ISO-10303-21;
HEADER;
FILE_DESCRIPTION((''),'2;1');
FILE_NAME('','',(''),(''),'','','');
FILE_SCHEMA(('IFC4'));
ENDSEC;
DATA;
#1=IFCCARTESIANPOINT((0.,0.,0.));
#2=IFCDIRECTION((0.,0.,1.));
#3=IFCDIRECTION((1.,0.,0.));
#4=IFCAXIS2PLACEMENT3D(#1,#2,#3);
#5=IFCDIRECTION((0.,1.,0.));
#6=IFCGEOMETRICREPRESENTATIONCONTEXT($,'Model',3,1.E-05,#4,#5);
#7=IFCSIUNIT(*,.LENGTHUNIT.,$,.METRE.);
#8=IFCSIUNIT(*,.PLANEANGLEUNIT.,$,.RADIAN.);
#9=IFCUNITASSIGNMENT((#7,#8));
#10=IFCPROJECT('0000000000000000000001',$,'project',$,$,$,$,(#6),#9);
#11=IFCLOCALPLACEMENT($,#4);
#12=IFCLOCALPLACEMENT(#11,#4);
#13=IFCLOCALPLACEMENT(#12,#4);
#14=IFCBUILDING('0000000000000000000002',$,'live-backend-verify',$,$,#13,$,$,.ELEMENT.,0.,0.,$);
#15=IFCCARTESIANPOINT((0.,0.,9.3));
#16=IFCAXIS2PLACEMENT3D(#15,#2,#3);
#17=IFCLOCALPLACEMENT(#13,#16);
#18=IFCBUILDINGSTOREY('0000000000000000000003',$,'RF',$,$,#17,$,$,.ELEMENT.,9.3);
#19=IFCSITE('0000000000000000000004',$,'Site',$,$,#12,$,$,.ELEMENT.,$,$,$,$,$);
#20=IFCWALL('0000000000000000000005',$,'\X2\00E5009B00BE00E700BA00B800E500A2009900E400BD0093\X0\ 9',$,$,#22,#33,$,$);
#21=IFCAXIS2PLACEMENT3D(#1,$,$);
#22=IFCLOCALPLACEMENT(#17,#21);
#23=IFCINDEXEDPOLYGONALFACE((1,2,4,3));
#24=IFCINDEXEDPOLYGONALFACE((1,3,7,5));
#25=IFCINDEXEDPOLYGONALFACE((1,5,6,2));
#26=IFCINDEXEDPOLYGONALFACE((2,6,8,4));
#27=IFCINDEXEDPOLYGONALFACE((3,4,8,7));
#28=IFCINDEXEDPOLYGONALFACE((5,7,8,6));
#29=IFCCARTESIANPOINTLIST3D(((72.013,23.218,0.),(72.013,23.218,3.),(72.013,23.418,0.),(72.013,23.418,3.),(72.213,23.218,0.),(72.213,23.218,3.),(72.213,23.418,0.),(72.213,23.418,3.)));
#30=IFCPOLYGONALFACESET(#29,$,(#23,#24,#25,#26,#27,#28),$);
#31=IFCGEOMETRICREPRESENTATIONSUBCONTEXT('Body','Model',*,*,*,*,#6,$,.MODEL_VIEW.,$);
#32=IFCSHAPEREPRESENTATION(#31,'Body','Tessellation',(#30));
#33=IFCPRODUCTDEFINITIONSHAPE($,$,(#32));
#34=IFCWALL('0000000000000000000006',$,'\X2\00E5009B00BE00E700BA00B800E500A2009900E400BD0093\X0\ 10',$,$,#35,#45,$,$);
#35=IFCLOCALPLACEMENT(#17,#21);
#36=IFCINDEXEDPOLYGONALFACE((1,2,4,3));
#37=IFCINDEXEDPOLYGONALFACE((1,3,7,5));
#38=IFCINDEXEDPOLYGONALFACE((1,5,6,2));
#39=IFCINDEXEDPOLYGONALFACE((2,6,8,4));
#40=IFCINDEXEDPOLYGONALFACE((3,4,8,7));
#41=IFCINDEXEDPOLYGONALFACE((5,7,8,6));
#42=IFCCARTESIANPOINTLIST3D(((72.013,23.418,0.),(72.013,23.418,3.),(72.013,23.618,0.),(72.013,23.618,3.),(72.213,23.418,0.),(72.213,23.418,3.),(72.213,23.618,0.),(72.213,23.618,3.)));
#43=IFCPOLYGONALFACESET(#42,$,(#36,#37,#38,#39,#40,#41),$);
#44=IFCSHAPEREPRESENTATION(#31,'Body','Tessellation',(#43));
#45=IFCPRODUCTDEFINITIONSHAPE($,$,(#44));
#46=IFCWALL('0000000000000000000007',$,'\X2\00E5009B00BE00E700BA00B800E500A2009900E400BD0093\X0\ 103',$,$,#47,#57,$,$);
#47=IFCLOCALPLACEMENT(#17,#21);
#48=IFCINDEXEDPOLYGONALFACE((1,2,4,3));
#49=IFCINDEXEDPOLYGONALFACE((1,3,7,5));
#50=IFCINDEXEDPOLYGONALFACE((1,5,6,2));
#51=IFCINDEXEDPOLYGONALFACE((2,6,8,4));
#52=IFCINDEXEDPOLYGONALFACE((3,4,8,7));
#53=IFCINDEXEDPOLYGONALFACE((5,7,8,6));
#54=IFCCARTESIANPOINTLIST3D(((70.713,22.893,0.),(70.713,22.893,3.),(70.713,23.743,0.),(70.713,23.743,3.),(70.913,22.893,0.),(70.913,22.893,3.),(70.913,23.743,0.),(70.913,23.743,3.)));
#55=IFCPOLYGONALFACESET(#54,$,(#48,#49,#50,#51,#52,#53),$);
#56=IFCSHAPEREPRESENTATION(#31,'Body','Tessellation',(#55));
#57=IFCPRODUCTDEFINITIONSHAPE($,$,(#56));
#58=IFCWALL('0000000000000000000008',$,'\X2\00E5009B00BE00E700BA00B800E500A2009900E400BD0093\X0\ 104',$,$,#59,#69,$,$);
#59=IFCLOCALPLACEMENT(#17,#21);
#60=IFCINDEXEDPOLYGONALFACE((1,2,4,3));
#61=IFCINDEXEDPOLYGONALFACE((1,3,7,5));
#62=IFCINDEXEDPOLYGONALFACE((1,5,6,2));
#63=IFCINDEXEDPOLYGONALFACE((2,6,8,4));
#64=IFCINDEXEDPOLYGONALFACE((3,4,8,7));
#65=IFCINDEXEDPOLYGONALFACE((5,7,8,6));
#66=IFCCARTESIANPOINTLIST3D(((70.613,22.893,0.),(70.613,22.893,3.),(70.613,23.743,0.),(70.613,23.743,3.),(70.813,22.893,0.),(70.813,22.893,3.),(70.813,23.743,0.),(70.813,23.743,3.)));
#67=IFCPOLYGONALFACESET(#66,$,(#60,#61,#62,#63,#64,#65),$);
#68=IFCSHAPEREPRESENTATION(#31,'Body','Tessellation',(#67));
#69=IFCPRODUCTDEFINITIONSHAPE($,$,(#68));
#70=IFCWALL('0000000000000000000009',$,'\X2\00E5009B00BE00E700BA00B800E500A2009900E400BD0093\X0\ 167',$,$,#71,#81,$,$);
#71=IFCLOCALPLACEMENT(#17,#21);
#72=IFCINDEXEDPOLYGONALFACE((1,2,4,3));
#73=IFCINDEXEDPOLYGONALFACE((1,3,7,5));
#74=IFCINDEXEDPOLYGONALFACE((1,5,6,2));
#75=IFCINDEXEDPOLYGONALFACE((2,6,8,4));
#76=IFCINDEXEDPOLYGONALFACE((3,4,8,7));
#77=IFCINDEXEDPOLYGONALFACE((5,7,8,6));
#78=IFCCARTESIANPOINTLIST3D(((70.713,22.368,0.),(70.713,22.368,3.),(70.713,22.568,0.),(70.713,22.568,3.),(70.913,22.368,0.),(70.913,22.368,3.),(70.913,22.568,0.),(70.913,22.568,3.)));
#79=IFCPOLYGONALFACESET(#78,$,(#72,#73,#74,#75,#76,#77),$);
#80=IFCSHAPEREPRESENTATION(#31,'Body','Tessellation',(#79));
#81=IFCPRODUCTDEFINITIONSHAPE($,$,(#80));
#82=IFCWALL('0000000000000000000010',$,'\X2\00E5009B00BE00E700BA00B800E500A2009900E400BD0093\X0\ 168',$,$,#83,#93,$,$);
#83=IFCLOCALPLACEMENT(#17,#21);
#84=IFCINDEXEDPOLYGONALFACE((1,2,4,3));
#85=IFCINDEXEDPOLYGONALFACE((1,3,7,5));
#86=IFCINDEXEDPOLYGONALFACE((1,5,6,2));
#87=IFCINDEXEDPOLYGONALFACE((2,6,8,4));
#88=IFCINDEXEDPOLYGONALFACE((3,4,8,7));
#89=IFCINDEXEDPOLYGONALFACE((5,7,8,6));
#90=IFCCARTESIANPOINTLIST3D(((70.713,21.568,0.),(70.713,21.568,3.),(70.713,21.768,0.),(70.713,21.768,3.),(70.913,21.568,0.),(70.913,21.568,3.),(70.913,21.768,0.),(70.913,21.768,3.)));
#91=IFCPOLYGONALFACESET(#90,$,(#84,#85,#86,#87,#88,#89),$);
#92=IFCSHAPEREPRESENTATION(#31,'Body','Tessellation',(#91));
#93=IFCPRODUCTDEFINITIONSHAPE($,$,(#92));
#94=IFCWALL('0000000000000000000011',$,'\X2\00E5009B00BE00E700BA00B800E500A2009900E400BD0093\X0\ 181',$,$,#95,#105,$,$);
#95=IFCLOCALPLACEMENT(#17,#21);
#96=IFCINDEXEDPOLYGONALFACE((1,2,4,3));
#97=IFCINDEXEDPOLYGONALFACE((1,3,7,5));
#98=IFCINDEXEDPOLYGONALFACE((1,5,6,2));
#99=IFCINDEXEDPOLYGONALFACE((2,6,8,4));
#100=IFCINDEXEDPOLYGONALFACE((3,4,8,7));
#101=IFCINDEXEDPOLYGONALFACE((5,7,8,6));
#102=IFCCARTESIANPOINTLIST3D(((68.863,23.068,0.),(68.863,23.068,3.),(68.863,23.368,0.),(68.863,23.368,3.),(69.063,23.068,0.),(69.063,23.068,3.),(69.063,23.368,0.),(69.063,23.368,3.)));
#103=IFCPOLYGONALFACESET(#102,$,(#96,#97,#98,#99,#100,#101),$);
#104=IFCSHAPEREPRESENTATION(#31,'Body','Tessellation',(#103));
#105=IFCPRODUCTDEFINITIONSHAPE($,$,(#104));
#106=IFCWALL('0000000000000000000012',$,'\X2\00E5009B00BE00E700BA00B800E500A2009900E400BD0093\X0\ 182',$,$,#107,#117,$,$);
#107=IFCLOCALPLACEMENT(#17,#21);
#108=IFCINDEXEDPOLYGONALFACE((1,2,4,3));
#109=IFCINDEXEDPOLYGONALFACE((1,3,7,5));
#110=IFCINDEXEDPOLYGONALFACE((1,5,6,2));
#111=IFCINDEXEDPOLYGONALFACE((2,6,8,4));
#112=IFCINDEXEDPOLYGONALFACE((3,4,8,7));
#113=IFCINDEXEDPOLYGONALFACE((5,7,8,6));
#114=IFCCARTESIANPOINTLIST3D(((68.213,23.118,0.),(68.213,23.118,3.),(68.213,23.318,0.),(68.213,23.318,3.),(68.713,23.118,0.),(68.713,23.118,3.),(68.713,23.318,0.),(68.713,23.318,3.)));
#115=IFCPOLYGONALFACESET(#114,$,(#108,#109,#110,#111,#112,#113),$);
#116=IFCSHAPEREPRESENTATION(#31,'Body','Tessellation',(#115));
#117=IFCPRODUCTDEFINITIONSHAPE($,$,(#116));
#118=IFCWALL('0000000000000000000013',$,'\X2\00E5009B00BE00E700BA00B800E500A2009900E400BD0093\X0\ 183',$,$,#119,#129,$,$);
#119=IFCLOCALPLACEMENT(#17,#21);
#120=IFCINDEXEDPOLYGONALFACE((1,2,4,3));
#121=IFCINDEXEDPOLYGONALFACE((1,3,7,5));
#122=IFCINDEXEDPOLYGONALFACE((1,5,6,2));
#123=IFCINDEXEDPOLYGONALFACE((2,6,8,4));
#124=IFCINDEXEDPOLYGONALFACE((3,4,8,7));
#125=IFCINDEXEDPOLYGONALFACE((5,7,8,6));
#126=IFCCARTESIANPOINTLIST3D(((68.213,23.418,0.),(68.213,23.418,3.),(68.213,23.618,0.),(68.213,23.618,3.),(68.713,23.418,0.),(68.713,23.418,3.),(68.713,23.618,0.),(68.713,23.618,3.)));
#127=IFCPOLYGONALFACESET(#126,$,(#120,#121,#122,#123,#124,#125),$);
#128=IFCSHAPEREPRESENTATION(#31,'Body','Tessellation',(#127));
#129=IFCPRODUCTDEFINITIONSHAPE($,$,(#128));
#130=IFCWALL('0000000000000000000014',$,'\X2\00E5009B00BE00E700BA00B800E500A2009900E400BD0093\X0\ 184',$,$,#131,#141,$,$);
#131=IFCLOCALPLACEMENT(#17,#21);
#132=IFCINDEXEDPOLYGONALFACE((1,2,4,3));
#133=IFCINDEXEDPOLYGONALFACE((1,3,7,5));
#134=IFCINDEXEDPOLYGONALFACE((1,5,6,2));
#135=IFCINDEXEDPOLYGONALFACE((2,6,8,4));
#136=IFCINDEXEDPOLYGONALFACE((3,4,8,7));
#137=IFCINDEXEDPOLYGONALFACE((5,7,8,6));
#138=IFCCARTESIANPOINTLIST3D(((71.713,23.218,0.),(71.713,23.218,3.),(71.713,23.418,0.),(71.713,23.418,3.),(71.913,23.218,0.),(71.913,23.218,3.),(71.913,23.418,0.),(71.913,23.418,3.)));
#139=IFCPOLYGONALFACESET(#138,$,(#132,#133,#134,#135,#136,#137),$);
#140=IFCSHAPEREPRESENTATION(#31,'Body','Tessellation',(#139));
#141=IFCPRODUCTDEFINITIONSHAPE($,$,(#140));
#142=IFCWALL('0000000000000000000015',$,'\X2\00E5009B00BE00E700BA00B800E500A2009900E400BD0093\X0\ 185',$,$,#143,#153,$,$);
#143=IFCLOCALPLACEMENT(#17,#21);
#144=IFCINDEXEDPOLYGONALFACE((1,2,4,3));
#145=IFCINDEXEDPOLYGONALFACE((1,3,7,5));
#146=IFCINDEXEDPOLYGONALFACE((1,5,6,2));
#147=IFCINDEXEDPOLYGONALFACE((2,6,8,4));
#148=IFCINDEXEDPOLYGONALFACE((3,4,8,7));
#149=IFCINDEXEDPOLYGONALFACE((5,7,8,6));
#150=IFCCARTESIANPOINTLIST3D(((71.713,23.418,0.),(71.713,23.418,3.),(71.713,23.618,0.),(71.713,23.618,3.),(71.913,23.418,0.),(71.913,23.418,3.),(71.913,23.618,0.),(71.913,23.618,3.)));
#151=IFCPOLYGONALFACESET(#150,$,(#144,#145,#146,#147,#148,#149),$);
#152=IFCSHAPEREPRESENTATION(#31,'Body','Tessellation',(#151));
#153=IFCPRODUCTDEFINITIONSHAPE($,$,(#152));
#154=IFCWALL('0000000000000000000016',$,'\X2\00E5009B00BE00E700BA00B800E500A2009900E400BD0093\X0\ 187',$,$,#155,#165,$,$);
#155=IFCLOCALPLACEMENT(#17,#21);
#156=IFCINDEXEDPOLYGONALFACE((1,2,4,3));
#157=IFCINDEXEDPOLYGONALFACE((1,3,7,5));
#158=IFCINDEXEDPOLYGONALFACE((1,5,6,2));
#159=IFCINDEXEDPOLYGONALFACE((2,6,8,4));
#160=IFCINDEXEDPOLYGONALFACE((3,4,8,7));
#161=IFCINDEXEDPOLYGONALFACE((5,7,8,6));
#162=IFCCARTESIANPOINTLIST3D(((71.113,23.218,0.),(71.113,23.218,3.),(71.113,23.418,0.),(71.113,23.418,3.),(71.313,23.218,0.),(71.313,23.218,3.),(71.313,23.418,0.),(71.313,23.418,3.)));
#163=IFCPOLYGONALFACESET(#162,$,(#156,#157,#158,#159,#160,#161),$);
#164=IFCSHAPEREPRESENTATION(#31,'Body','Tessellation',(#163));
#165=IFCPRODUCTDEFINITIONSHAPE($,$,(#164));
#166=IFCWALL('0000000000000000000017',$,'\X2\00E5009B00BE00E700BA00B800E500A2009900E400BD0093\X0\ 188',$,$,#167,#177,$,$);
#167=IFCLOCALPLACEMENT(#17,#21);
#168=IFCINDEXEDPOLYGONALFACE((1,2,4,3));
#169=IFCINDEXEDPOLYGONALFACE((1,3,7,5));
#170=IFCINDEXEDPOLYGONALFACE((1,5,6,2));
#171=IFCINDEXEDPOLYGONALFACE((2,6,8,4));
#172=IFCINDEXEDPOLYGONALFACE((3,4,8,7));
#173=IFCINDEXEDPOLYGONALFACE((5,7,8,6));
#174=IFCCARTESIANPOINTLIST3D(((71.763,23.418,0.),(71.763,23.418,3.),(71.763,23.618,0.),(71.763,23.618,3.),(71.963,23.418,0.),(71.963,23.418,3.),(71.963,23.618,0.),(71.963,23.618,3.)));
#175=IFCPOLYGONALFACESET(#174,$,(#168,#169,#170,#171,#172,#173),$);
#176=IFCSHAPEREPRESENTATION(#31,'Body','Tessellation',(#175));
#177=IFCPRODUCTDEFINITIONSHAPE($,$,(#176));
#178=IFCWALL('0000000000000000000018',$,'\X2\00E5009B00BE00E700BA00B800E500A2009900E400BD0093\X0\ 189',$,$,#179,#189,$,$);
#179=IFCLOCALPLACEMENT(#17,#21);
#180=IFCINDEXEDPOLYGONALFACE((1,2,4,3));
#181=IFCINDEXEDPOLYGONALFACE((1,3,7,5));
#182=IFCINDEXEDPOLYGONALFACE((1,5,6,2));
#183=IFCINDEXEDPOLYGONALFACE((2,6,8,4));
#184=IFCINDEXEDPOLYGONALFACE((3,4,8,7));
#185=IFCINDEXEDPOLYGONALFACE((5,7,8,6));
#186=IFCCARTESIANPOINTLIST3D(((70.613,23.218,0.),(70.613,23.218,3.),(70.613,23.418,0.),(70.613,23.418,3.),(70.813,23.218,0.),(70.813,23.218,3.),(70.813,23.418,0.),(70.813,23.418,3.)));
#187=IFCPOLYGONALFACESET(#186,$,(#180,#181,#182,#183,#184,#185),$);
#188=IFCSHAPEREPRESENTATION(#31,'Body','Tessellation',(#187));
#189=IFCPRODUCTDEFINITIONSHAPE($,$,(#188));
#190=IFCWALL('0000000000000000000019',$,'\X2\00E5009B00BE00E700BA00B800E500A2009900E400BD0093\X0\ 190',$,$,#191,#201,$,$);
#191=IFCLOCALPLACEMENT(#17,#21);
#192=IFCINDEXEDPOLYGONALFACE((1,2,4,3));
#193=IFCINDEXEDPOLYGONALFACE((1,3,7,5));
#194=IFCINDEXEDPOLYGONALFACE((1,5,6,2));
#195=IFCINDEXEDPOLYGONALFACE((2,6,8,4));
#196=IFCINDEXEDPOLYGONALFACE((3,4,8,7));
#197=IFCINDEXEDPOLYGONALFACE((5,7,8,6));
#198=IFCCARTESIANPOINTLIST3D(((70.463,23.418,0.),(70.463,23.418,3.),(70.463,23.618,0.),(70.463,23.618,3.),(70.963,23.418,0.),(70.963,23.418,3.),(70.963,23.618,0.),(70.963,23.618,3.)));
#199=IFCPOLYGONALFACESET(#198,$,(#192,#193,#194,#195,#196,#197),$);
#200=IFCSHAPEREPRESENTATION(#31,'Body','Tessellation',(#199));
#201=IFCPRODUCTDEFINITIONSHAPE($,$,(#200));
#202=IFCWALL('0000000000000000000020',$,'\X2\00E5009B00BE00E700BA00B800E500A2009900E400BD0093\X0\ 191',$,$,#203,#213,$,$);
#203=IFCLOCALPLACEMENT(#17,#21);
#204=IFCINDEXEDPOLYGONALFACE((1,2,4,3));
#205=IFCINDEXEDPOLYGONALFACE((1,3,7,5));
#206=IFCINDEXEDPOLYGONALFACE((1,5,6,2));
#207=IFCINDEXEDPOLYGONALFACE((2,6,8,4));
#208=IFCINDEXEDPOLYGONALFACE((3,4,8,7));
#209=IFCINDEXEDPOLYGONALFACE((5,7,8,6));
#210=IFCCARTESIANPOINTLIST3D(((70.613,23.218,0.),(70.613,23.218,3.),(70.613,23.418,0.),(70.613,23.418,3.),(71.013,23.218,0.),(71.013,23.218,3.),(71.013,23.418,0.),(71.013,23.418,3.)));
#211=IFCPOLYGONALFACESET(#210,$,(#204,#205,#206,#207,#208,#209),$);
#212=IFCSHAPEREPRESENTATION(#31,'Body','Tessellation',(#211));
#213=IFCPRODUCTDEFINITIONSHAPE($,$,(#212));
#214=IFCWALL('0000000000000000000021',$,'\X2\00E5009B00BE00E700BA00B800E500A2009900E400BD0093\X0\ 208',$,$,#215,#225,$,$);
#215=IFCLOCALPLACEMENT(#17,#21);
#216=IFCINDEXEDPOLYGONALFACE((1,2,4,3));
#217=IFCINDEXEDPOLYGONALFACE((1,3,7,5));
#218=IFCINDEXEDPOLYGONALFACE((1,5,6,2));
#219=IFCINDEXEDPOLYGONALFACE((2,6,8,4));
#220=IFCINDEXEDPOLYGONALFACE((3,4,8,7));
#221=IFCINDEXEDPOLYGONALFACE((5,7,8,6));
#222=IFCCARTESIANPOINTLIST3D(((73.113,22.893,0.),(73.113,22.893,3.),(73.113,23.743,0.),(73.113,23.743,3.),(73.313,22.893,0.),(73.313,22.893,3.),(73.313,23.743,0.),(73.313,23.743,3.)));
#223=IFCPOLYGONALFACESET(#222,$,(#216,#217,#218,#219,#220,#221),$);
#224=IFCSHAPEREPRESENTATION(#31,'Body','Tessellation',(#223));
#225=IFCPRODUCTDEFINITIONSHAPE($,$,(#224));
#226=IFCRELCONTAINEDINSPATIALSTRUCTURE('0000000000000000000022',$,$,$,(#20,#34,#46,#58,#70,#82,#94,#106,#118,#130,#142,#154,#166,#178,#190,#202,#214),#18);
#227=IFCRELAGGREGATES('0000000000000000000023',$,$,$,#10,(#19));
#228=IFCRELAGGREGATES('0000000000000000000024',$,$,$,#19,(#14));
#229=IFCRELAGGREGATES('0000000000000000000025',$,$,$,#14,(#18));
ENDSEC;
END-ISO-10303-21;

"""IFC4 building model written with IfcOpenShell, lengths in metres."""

from ifc_helpers import new_model, si_unit, direction, frame, frame_2d, origin_with_axes, place, context, subcontext, project, spatial, rectangle, extrude, element, save


model = new_model("IFC4")

# Units and contexts
model_context = context("Model", 3, precision=1e-05, world=origin_with_axes(), true_north=direction((0.0, 1.0, 0.0)))
body_context = subcontext(model_context, "Body", "Model", "MODEL_VIEW")
ifc_project = project(units=[si_unit("LENGTHUNIT", "METRE"), si_unit("PLANEANGLEUNIT", "RADIAN")], contexts=[model_context])

# Site, building, storey
placement = place(None, origin_with_axes())
site_placement = place(placement, origin_with_axes())
site = spatial("IfcSite", under=ifc_project, at=site_placement, Name="Site", CompositionType="ELEMENT")
building_placement = place(site_placement, origin_with_axes())
building = spatial("IfcBuilding", under=site, at=building_placement, Name="live-backend-verify", CompositionType="ELEMENT", ElevationOfRefHeight=0.0, ElevationOfTerrain=0.0)
storey_placement = place(building_placement, frame((0.0, 0.0, 9.3), z_axis=(0.0, 0.0, 1.0), x_axis=(1.0, 0.0, 0.0)))
storey = spatial("IfcBuildingStorey", under=building, at=storey_placement, Name="RF", CompositionType="ELEMENT", Elevation=9.3)

# Walls
for number, where, z_axis, x_axis, name in (
    (1, (72.113, 23.318, 0.0), (0.0, 0.0, 1.0), (-1.0, 0.0, 0.0), "å\u009b¾çº¸å¢\u0099ä½\u0093 9"),
    (2, (72.113, 23.518, 0.0), (0.0, 0.0, 1.0), (-1.0, 0.0, 0.0), "å\u009b¾çº¸å¢\u0099ä½\u0093 10"),
):
    element("IfcWall", number, at=place(storey_placement, frame(where, z_axis=z_axis, x_axis=x_axis)), inside=storey, Name=name, context=body_context, shape_type="SweptSolid", body=[
        extrude(rectangle(XDim=0.2, YDim=0.2, at=frame_2d((0.0, 0.0), x_axis=(1.0, 0.0, 0.0))), frame((0.0, 0.0, 0.0), z_axis=(0.0, 0.0, 1.0)), (0.0, 0.0, 1.0), 3.0),
    ])
for number, where, z_axis, x_axis, name in (
    (3, (70.813, 23.318, 0.0), (0.0, 0.0, 1.0), (0.0, -1.0, 0.0), "å\u009b¾çº¸å¢\u0099ä½\u0093 103"),
    (4, (70.713, 23.318, 0.0), (0.0, 0.0, 1.0), (0.0, -1.0, 0.0), "å\u009b¾çº¸å¢\u0099ä½\u0093 104"),
):
    element("IfcWall", number, at=place(storey_placement, frame(where, z_axis=z_axis, x_axis=x_axis)), inside=storey, Name=name, context=body_context, shape_type="SweptSolid", body=[
        extrude(rectangle(XDim=0.85, YDim=0.2, at=frame_2d((0.0, 0.0), x_axis=(1.0, 0.0, 0.0))), frame((0.0, 0.0, 0.0), z_axis=(0.0, 0.0, 1.0)), (0.0, 0.0, 1.0), 3.0),
    ])
for number, where, z_axis, x_axis, name in (
    (5, (70.813, 22.468, 0.0), (0.0, 0.0, 1.0), (-1.0, 0.0, 0.0), "å\u009b¾çº¸å¢\u0099ä½\u0093 167"),
    (6, (70.813, 21.668, 0.0), (0.0, 0.0, 1.0), (0.0, -1.0, 0.0), "å\u009b¾çº¸å¢\u0099ä½\u0093 168"),
):
    element("IfcWall", number, at=place(storey_placement, frame(where, z_axis=z_axis, x_axis=x_axis)), inside=storey, Name=name, context=body_context, shape_type="SweptSolid", body=[
        extrude(rectangle(XDim=0.2, YDim=0.2, at=frame_2d((0.0, 0.0), x_axis=(1.0, 0.0, 0.0))), frame((0.0, 0.0, 0.0), z_axis=(0.0, 0.0, 1.0)), (0.0, 0.0, 1.0), 3.0),
    ])
wall_1_placement = place(storey_placement, frame((68.963, 23.218, 0.0), z_axis=(0.0, 0.0, 1.0), x_axis=(0.0, 1.0, 0.0)))
element("IfcWall", 7, at=wall_1_placement, inside=storey, Name="å\u009b¾çº¸å¢\u0099ä½\u0093 181", context=body_context, shape_type="SweptSolid", body=[
    extrude(rectangle(XDim=0.3, YDim=0.2, at=frame_2d((0.0, 0.0), x_axis=(1.0, 0.0, 0.0))), frame((0.0, 0.0, 0.0), z_axis=(0.0, 0.0, 1.0)), (0.0, 0.0, 1.0), 3.0),
])
for number, where, z_axis, x_axis, name in (
    (8, (68.463, 23.218, 0.0), (0.0, 0.0, 1.0), (1.0, 0.0, 0.0), "å\u009b¾çº¸å¢\u0099ä½\u0093 182"),
    (9, (68.463, 23.518, 0.0), (0.0, 0.0, 1.0), (1.0, 0.0, 0.0), "å\u009b¾çº¸å¢\u0099ä½\u0093 183"),
):
    element("IfcWall", number, at=place(storey_placement, frame(where, z_axis=z_axis, x_axis=x_axis)), inside=storey, Name=name, context=body_context, shape_type="SweptSolid", body=[
        extrude(rectangle(XDim=0.5, YDim=0.2, at=frame_2d((0.0, 0.0), x_axis=(1.0, 0.0, 0.0))), frame((0.0, 0.0, 0.0), z_axis=(0.0, 0.0, 1.0)), (0.0, 0.0, 1.0), 3.0),
    ])
for number, where, z_axis, x_axis, name in (
    (10, (71.813, 23.318, 0.0), (0.0, 0.0, 1.0), (1.0, 0.0, 0.0), "å\u009b¾çº¸å¢\u0099ä½\u0093 184"),
    (11, (71.813, 23.518, 0.0), (0.0, 0.0, 1.0), (1.0, 0.0, 0.0), "å\u009b¾çº¸å¢\u0099ä½\u0093 185"),
    (12, (71.213, 23.318, 0.0), (0.0, 0.0, 1.0), (0.0, 1.0, 0.0), "å\u009b¾çº¸å¢\u0099ä½\u0093 187"),
    (13, (71.863, 23.518, 0.0), (0.0, 0.0, 1.0), (1.0, 0.0, 0.0), "å\u009b¾çº¸å¢\u0099ä½\u0093 188"),
    (14, (70.713, 23.318, 0.0), (0.0, 0.0, 1.0), (0.0, 1.0, 0.0), "å\u009b¾çº¸å¢\u0099ä½\u0093 189"),
):
    element("IfcWall", number, at=place(storey_placement, frame(where, z_axis=z_axis, x_axis=x_axis)), inside=storey, Name=name, context=body_context, shape_type="SweptSolid", body=[
        extrude(rectangle(XDim=0.2, YDim=0.2, at=frame_2d((0.0, 0.0), x_axis=(1.0, 0.0, 0.0))), frame((0.0, 0.0, 0.0), z_axis=(0.0, 0.0, 1.0)), (0.0, 0.0, 1.0), 3.0),
    ])
wall_2_placement = place(storey_placement, frame((70.713, 23.518, 0.0), z_axis=(0.0, 0.0, 1.0), x_axis=(1.0, 0.0, 0.0)))
element("IfcWall", 15, at=wall_2_placement, inside=storey, Name="å\u009b¾çº¸å¢\u0099ä½\u0093 190", context=body_context, shape_type="SweptSolid", body=[
    extrude(rectangle(XDim=0.5, YDim=0.2, at=frame_2d((0.0, 0.0), x_axis=(1.0, 0.0, 0.0))), frame((0.0, 0.0, 0.0), z_axis=(0.0, 0.0, 1.0)), (0.0, 0.0, 1.0), 3.0),
])
wall_3_placement = place(storey_placement, frame((70.813, 23.318, 0.0), z_axis=(0.0, 0.0, 1.0), x_axis=(1.0, 0.0, 0.0)))
element("IfcWall", 16, at=wall_3_placement, inside=storey, Name="å\u009b¾çº¸å¢\u0099ä½\u0093 191", context=body_context, shape_type="SweptSolid", body=[
    extrude(rectangle(XDim=0.4, YDim=0.2, at=frame_2d((0.0, 0.0), x_axis=(1.0, 0.0, 0.0))), frame((0.0, 0.0, 0.0), z_axis=(0.0, 0.0, 1.0)), (0.0, 0.0, 1.0), 3.0),
])
for number, where, z_axis, x_axis, name in (
    (17, (73.213, 23.318, 0.0), (0.0, 0.0, 1.0), (0.0, -1.0, 0.0), "å\u009b¾çº¸å¢\u0099ä½\u0093 208"),
):
    element("IfcWall", number, at=place(storey_placement, frame(where, z_axis=z_axis, x_axis=x_axis)), inside=storey, Name=name, context=body_context, shape_type="SweptSolid", body=[
        extrude(rectangle(XDim=0.85, YDim=0.2, at=frame_2d((0.0, 0.0), x_axis=(1.0, 0.0, 0.0))), frame((0.0, 0.0, 0.0), z_axis=(0.0, 0.0, 1.0)), (0.0, 0.0, 1.0), 3.0),
    ])

save(model, "model.ifc")
